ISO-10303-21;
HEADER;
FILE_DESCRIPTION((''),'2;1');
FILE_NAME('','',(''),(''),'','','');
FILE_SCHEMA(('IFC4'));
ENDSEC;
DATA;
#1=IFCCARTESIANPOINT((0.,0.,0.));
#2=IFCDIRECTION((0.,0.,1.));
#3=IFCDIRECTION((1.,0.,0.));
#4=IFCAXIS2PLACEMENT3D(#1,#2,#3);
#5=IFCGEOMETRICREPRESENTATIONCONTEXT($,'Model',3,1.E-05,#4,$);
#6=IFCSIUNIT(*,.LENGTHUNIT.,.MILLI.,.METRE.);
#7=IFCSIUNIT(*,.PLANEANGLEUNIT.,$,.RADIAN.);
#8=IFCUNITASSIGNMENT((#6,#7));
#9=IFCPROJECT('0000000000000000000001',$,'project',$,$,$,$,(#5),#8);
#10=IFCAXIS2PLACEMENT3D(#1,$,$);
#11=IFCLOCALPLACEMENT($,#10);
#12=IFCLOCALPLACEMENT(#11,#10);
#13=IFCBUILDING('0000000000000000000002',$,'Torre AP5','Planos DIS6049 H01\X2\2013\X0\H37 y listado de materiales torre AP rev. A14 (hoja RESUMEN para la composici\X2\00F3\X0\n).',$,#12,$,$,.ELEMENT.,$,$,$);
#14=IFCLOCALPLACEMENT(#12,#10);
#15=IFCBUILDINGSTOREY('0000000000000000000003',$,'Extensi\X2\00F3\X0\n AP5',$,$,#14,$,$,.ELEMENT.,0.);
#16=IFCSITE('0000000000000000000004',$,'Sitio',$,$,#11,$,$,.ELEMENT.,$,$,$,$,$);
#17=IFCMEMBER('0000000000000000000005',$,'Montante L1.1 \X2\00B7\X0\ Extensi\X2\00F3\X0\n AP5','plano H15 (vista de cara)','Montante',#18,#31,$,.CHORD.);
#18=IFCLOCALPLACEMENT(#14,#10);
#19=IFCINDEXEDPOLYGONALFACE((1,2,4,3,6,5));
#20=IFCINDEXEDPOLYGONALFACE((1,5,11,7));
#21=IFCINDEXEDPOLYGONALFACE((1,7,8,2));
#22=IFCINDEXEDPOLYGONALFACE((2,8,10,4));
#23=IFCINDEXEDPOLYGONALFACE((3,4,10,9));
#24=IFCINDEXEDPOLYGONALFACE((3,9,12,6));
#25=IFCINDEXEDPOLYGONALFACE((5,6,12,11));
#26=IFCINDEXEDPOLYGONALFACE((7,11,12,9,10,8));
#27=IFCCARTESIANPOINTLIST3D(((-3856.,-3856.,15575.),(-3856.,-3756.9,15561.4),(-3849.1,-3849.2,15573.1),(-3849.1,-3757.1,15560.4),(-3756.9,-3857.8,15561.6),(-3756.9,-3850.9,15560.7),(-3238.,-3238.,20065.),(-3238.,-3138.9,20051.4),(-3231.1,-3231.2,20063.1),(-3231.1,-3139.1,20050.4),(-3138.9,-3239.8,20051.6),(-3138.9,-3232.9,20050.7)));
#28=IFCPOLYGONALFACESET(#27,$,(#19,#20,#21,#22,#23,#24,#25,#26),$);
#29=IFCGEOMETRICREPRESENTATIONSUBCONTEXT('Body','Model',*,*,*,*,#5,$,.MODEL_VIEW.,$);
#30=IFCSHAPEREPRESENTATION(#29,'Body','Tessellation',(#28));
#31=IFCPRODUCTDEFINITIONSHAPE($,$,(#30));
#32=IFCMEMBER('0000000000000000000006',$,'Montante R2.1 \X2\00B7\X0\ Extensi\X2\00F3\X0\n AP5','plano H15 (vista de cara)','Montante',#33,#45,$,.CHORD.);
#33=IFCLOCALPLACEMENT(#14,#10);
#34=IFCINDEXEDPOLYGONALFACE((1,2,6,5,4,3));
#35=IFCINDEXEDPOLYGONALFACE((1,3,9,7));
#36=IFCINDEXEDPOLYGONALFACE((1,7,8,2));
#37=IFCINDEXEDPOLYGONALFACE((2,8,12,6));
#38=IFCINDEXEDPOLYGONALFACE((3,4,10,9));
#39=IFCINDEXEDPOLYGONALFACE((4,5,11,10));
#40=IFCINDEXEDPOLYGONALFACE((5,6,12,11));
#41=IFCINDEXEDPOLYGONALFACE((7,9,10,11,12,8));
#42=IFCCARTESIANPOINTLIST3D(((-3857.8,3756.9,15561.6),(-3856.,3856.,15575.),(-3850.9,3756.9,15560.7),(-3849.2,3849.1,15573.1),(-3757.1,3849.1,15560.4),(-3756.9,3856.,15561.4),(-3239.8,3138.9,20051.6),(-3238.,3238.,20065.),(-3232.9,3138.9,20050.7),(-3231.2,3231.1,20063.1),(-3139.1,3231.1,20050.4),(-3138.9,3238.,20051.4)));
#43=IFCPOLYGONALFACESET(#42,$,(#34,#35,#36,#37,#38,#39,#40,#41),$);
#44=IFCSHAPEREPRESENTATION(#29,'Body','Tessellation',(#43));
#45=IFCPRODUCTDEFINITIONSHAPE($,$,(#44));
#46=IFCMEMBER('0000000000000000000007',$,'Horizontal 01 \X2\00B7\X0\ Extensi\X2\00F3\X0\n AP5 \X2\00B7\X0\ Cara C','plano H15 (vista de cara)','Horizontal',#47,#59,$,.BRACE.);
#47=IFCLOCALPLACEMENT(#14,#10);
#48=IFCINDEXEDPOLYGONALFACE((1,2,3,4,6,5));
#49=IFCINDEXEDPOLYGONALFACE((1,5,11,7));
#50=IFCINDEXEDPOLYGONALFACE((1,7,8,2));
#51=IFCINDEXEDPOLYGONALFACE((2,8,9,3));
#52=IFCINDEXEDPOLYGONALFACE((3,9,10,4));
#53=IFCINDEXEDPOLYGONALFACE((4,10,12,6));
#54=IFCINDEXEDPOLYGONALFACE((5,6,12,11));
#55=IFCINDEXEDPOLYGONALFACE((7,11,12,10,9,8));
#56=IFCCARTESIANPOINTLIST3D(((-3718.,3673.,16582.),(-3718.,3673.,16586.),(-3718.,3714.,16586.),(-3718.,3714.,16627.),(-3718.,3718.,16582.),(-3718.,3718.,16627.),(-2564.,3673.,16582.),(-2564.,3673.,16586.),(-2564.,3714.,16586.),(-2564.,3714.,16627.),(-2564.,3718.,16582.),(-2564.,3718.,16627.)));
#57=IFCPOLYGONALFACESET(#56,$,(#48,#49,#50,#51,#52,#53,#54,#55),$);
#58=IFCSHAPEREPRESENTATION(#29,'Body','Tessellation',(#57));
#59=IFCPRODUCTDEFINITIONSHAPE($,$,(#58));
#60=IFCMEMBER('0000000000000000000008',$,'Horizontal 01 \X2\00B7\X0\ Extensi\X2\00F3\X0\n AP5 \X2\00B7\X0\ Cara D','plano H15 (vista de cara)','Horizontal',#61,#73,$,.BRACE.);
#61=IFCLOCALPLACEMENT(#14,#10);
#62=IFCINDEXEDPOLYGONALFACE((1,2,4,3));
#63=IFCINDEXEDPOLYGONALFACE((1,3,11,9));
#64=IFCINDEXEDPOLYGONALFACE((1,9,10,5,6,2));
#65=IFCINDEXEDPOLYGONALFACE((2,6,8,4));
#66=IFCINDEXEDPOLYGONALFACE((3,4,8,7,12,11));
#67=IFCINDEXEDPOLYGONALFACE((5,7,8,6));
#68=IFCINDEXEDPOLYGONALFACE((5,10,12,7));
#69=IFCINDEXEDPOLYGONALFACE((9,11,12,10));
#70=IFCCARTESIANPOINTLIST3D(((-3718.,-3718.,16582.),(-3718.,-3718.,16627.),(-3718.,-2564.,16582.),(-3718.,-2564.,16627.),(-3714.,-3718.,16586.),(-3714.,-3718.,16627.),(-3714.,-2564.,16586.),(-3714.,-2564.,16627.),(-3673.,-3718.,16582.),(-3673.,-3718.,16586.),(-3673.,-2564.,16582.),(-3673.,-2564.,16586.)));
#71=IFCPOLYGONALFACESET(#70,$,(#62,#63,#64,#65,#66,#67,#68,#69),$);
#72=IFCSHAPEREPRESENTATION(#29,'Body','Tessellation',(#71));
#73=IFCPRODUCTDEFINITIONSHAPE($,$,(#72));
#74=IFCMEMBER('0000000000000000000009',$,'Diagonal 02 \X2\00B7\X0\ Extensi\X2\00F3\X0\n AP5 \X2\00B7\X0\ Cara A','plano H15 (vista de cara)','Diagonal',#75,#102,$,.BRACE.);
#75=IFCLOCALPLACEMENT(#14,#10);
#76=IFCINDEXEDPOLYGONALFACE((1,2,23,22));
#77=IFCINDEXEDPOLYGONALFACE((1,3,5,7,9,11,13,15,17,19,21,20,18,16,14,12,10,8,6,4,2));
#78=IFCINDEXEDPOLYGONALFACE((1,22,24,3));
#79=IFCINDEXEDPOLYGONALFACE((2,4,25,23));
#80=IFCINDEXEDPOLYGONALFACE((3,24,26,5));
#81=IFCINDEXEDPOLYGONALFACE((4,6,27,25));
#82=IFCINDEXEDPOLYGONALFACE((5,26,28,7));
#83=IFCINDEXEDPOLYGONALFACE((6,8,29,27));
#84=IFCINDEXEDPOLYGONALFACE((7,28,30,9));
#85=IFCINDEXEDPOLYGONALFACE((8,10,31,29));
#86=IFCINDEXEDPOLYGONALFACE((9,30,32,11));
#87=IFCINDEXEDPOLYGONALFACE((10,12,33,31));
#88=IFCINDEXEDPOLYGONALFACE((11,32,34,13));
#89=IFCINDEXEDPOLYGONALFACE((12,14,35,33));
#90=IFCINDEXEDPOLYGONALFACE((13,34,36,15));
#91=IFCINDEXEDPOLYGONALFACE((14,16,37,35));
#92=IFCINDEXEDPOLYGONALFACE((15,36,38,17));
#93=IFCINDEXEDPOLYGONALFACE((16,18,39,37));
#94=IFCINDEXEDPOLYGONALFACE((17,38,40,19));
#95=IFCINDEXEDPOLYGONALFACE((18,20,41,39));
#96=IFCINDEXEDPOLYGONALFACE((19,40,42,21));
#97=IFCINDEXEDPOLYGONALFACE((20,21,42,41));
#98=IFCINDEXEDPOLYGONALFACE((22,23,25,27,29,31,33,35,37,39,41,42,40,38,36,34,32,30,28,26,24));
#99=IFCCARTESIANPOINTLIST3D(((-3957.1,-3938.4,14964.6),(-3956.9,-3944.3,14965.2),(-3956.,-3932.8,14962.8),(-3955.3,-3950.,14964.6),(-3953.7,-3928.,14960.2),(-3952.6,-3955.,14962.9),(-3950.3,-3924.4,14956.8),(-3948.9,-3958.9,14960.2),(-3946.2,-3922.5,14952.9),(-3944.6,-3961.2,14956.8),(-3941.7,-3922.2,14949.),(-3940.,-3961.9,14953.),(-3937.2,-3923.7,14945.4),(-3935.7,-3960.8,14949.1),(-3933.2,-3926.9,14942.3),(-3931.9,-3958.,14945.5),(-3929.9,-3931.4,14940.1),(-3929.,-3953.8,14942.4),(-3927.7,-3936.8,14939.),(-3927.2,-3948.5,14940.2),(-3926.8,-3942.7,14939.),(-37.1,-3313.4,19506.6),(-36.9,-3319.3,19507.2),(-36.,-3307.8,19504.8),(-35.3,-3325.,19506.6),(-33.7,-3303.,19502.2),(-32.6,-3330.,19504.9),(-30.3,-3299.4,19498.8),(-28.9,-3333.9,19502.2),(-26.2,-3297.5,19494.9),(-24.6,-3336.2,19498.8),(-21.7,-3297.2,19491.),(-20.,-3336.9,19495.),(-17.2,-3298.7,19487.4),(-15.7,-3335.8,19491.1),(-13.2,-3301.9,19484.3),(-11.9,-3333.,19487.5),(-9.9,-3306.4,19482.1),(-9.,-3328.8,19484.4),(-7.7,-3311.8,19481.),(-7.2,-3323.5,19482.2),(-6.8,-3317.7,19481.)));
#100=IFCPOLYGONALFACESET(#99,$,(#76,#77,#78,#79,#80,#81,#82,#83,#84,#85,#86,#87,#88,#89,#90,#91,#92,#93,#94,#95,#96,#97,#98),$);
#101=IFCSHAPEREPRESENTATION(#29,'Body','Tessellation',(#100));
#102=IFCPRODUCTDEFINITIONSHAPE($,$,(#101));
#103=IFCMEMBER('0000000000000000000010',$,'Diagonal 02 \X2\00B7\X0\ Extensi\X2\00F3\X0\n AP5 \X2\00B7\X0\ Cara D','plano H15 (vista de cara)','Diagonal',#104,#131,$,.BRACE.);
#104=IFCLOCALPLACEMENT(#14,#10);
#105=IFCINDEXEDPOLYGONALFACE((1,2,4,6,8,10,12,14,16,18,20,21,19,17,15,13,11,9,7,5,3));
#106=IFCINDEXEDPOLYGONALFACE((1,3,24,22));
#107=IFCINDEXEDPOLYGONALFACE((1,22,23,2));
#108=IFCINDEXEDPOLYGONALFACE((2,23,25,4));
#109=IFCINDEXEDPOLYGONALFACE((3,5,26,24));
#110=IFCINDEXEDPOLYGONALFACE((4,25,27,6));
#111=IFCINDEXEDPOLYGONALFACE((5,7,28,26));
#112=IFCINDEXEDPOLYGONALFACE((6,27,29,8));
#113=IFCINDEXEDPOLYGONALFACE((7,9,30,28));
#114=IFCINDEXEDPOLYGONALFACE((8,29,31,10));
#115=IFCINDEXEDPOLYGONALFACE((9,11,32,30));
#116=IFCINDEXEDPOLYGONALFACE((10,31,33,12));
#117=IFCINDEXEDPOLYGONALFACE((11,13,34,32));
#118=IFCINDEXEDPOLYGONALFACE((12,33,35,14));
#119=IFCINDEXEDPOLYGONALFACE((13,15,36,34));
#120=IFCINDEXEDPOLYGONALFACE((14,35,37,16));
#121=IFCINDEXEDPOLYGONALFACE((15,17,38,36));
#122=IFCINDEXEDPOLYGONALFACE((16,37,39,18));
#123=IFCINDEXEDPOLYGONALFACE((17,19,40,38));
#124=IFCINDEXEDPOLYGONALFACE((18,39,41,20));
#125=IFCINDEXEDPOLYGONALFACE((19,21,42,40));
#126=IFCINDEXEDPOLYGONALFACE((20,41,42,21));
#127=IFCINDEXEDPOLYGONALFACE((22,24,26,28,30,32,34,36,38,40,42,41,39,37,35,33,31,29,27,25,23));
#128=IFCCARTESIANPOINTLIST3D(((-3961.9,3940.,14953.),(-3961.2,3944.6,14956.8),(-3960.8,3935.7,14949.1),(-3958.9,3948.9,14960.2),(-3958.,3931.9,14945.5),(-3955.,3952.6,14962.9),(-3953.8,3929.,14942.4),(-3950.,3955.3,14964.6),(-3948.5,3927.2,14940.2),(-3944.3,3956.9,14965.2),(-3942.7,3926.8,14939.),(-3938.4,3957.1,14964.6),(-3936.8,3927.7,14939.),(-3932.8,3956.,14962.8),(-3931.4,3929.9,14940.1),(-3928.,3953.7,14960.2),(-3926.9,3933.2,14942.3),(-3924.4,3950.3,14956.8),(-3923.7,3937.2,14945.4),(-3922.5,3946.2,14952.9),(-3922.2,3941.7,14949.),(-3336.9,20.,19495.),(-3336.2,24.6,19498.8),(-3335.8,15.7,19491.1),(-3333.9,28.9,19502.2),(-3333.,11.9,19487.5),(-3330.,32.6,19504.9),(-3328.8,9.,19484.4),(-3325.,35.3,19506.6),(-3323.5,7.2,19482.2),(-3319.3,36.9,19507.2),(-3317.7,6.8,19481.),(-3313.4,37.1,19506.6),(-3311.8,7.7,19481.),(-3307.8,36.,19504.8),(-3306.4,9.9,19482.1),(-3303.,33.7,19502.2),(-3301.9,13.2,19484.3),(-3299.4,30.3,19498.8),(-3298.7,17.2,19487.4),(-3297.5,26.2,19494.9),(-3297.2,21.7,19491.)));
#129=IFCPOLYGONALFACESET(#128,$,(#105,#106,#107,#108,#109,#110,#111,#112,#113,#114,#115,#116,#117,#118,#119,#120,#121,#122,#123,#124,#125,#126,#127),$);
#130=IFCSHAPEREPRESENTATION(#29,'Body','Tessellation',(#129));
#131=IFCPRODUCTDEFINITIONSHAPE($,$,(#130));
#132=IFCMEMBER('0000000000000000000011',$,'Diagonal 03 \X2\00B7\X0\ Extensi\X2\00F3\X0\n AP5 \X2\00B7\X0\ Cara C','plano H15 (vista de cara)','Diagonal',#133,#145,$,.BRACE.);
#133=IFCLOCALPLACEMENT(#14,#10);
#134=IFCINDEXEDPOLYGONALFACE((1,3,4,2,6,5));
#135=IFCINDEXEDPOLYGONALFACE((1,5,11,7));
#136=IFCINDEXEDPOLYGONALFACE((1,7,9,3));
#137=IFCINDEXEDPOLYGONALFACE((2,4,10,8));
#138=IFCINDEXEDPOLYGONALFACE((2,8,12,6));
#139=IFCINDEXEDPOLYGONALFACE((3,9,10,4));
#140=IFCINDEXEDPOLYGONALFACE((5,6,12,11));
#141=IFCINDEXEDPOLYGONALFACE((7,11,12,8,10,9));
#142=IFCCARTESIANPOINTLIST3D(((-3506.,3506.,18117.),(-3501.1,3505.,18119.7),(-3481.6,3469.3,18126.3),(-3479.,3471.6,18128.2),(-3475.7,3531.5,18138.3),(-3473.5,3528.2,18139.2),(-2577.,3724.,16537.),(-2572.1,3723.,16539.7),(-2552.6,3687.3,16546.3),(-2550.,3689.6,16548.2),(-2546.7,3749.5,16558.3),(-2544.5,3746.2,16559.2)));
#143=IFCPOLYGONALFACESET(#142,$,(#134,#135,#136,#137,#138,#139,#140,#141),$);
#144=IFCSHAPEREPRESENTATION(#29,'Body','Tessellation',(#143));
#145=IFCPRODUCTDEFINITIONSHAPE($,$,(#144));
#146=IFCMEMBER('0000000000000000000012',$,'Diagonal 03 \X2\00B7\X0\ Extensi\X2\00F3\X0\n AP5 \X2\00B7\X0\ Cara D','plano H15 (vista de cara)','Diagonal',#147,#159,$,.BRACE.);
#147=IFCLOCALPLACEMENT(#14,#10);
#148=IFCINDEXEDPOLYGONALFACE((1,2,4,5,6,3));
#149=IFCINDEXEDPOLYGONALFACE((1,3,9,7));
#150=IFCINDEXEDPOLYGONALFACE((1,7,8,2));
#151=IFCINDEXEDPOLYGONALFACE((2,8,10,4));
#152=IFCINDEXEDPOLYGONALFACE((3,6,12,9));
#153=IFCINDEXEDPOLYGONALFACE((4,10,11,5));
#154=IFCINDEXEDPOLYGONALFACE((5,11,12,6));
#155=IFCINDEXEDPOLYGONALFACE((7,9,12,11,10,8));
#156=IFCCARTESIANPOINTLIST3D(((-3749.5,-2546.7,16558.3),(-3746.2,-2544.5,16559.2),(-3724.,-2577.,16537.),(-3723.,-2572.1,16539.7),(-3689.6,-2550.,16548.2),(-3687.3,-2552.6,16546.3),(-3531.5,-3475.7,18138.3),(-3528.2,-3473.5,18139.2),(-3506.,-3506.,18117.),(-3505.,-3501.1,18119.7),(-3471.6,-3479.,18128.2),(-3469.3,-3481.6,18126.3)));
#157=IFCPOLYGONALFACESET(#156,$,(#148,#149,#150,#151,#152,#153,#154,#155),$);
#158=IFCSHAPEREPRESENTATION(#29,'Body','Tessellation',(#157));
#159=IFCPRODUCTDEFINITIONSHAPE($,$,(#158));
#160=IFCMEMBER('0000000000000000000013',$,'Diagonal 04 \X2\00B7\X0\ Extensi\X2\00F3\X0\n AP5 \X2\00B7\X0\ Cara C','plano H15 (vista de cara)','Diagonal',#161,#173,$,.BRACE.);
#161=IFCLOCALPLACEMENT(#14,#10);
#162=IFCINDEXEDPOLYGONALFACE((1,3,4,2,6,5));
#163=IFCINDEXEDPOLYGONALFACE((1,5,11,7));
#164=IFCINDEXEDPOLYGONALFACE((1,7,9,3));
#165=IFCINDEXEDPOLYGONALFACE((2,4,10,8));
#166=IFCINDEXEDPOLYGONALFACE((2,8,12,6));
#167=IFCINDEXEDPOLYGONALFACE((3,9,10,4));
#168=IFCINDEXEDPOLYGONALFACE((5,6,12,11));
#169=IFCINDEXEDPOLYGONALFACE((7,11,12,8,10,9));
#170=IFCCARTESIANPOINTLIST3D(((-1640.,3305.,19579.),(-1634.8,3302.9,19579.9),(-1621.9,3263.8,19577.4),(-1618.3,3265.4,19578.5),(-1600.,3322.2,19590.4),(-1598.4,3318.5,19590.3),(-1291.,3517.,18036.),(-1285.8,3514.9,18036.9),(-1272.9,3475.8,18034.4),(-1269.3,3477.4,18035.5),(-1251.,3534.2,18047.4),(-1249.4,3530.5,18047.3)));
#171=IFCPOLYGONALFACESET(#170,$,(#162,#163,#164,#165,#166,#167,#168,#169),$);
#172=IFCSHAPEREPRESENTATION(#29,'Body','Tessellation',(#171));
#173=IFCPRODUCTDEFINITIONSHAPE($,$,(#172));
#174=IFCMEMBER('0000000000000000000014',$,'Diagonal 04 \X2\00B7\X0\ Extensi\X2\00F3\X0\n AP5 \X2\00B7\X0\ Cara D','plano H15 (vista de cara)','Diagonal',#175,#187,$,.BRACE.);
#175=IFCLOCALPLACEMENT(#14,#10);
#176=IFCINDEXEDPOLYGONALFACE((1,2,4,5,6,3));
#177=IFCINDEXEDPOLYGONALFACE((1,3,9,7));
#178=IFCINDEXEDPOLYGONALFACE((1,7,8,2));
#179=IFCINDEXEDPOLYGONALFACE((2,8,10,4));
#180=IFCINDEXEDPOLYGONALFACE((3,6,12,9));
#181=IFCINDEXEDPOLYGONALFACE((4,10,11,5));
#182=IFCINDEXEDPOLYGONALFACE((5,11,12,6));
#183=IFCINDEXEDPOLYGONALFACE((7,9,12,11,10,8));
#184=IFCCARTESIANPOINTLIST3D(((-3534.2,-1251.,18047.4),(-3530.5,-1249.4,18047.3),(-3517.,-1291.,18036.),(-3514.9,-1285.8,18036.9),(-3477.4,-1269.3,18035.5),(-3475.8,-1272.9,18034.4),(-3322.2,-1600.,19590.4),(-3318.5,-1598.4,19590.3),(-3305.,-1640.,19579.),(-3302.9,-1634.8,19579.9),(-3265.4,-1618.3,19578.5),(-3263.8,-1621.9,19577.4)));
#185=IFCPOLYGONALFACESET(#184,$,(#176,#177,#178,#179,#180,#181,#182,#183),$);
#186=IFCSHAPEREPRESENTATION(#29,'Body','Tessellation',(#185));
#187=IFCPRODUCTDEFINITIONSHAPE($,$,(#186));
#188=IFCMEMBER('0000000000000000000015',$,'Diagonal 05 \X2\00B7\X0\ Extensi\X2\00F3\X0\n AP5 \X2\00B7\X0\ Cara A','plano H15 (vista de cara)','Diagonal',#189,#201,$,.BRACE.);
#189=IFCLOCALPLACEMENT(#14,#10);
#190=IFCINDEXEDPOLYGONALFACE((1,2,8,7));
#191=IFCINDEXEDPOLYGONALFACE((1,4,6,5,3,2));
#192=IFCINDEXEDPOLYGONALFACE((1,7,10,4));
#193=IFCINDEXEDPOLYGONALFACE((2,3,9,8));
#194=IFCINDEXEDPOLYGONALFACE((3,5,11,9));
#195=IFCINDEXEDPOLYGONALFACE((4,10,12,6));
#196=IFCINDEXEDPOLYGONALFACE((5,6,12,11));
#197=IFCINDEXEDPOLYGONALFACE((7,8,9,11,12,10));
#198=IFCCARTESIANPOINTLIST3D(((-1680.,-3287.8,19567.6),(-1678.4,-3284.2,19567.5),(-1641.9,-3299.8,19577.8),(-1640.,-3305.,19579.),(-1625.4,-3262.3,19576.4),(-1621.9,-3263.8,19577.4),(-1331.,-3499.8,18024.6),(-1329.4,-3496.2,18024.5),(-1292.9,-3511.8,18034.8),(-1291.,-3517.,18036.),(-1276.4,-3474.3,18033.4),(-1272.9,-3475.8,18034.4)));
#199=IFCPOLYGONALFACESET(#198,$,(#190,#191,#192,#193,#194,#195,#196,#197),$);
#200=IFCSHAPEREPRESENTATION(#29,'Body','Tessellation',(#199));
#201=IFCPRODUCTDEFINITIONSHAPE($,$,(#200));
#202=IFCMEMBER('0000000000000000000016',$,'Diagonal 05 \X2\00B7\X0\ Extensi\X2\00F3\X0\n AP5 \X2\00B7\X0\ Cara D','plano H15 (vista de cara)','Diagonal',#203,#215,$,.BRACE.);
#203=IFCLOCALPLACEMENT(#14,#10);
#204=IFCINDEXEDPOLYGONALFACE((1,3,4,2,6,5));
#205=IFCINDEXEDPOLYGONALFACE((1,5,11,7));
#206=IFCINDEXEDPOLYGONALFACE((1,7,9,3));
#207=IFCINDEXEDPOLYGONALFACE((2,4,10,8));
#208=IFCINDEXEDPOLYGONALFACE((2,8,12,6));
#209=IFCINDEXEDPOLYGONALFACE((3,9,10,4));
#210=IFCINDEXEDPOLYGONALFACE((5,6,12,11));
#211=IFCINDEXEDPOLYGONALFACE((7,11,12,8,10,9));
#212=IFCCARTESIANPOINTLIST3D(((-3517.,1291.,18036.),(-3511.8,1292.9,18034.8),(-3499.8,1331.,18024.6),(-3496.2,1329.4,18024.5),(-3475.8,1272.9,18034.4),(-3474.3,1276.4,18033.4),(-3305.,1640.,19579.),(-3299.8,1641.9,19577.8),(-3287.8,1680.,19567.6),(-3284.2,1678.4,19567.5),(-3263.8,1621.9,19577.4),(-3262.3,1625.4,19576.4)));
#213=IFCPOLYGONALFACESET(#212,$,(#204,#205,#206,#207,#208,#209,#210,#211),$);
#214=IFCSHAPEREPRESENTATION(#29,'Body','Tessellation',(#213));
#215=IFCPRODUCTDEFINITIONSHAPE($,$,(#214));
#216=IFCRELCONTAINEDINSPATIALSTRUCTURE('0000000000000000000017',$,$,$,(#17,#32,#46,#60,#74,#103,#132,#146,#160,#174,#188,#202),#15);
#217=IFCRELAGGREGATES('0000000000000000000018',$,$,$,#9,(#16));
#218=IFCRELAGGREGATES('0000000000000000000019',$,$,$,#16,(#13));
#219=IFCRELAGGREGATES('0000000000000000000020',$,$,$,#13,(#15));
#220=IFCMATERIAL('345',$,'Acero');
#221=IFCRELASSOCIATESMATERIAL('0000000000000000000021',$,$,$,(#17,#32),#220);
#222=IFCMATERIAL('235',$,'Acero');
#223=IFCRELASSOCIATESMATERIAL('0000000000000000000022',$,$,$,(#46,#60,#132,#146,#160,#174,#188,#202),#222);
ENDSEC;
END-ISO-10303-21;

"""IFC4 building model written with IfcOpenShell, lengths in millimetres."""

from ifc_helpers import new_model, si_unit, frame, frame_2d, origin, origin_with_axes, place, context, subcontext, project, spatial, circle, l_section, extrude, material, element, save


model = new_model("IFC4")

# Units and contexts
model_context = context("Model", 3, precision=1e-05, world=origin_with_axes())
body_context = subcontext(model_context, "Body", "Model", "MODEL_VIEW")
ifc_project = project(units=[si_unit("LENGTHUNIT", "METRE", prefix="MILLI"), si_unit("PLANEANGLEUNIT", "RADIAN")], contexts=[model_context])

# Site, building, storey
site_placement = place(None, origin())
site = spatial("IfcSite", under=ifc_project, at=site_placement, Name="Sitio", CompositionType="ELEMENT")
building_placement = place(site_placement, origin())
building = spatial("IfcBuilding", under=site, at=building_placement, Name="Torre AP5", Description="Planos DIS6049 H01–H37 y listado de materiales torre AP rev. A14 (hoja RESUMEN para la composición).", CompositionType="ELEMENT")
storey_placement = place(building_placement, origin())
storey = spatial("IfcBuildingStorey", under=building, at=storey_placement, Name="Extensión AP5", CompositionType="ELEMENT", Elevation=0.0)

# Members
ifc_material_1 = material(Name="345", Category="Acero")
for number, where, z_axis, x_axis, name in (
    (1, (-3856.0, -3856.0, 15575.0), (0.135104, 0.135104, 0.981577), (0.990831, -0.018422, -0.133842), "Montante L1.1 · Extensión AP5"),
    (2, (-3856.0, 3856.0, 15575.0), (0.135104, -0.135104, 0.981577), (-0.018422, -0.990831, -0.133842), "Montante R2.1 · Extensión AP5"),
):
    element("IfcMember", number, at=place(storey_placement, frame(where, z_axis=z_axis, x_axis=x_axis)), inside=storey, material=ifc_material_1, Name=name, Description="plano H15 (vista de cara)", ObjectType="Montante", PredefinedType="CHORD", context=body_context, shape_type="SweptSolid", body=[
        extrude(l_section(Depth=100.0, Width=100.0, Thickness=7.0, at=frame_2d((50.0, 50.0))), None, (0.0, 0.0, 1.0), 4574.3),
    ])
ifc_material_2 = material(Name="235", Category="Acero")
for number, where, z_axis, x_axis, name in (
    (3, (-2564.0, 3718.0, 16582.0), (-1.0, 0.0, 0.0), (0.0, -1.0, 0.0), "Horizontal 01 · Extensión AP5 · Cara C"),
    (4, (-3718.0, -2564.0, 16582.0), (0.0, -1.0, 0.0), (1.0, 0.0, 0.0), "Horizontal 01 · Extensión AP5 · Cara D"),
):
    element("IfcMember", number, at=place(storey_placement, frame(where, z_axis=z_axis, x_axis=x_axis)), inside=storey, material=ifc_material_2, Name=name, Description="plano H15 (vista de cara)", ObjectType="Horizontal", PredefinedType="BRACE", context=body_context, shape_type="SweptSolid", body=[
        extrude(l_section(Depth=45.0, Width=45.0, Thickness=4.0, at=frame_2d((22.5, 22.5))), None, (0.0, 0.0, 1.0), 1154.0),
    ])
for number, where, z_axis, x_axis, name in (
    (5, (-3942.0, -3942.0, 14952.0), (0.649852, 0.103612, 0.752966), (0.237889, 0.913165, -0.330967), "Diagonal 02 · Extensión AP5 · Cara A"),
    (6, (-3942.0, 3942.0, 14952.0), (0.103612, -0.649852, 0.752966), (0.913165, -0.237889, -0.330967), "Diagonal 02 · Extensión AP5 · Cara D"),
):
    element("IfcMember", number, at=place(storey_placement, frame(where, z_axis=z_axis, x_axis=x_axis)), inside=storey, Name=name, Description="plano H15 (vista de cara)", ObjectType="Diagonal", PredefinedType="BRACE", context=body_context, shape_type="SweptSolid", body=[
        extrude(circle(Radius=20.0), None, (0.0, 0.0, 1.0), 6032.1),
    ])
for number, where, z_axis, x_axis, name in (
    (7, (-2577.0, 3724.0, 16537.0), (-0.503306, -0.118106, 0.855999), (0.541181, -0.815359, 0.205702), "Diagonal 03 · Extensión AP5 · Cara C"),
    (8, (-3724.0, -2577.0, 16537.0), (0.118106, -0.503306, 0.855999), (0.815359, 0.541181, 0.205702), "Diagonal 03 · Extensión AP5 · Cara D"),
):
    element("IfcMember", number, at=place(storey_placement, frame(where, z_axis=z_axis, x_axis=x_axis)), inside=storey, material=ifc_material_2, Name=name, Description="plano H15 (vista de cara)", ObjectType="Diagonal", PredefinedType="BRACE", context=body_context, shape_type="SweptSolid", body=[
        extrude(l_section(Depth=45.0, Width=45.0, Thickness=4.0, at=frame_2d((22.5, 22.5))), None, (0.0, 0.0, 1.0), 1845.8),
    ])
for number, where, z_axis, x_axis, name in (
    (9, (-1291.0, 3517.0, 18036.0), (-0.218655, -0.132822, 0.96672), (0.402816, -0.914628, -0.034555), "Diagonal 04 · Extensión AP5 · Cara C"),
    (10, (-3517.0, -1291.0, 18036.0), (0.132822, -0.218655, 0.96672), (0.914628, 0.402816, -0.034555), "Diagonal 04 · Extensión AP5 · Cara D"),
    (11, (-1291.0, -3517.0, 18036.0), (-0.218655, 0.132822, 0.96672), (0.402816, 0.914628, -0.034555), "Diagonal 05 · Extensión AP5 · Cara A"),
    (12, (-3517.0, 1291.0, 18036.0), (0.132822, 0.218655, 0.96672), (0.914628, -0.402816, -0.034555), "Diagonal 05 · Extensión AP5 · Cara D"),
):
    element("IfcMember", number, at=place(storey_placement, frame(where, z_axis=z_axis, x_axis=x_axis)), inside=storey, material=ifc_material_2, Name=name, Description="plano H15 (vista de cara)", ObjectType="Diagonal", PredefinedType="BRACE", context=body_context, shape_type="SweptSolid", body=[
        extrude(l_section(Depth=45.0, Width=45.0, Thickness=4.0, at=frame_2d((22.5, 22.5))), None, (0.0, 0.0, 1.0), 1596.1),
    ])

save(model, "model.ifc")
